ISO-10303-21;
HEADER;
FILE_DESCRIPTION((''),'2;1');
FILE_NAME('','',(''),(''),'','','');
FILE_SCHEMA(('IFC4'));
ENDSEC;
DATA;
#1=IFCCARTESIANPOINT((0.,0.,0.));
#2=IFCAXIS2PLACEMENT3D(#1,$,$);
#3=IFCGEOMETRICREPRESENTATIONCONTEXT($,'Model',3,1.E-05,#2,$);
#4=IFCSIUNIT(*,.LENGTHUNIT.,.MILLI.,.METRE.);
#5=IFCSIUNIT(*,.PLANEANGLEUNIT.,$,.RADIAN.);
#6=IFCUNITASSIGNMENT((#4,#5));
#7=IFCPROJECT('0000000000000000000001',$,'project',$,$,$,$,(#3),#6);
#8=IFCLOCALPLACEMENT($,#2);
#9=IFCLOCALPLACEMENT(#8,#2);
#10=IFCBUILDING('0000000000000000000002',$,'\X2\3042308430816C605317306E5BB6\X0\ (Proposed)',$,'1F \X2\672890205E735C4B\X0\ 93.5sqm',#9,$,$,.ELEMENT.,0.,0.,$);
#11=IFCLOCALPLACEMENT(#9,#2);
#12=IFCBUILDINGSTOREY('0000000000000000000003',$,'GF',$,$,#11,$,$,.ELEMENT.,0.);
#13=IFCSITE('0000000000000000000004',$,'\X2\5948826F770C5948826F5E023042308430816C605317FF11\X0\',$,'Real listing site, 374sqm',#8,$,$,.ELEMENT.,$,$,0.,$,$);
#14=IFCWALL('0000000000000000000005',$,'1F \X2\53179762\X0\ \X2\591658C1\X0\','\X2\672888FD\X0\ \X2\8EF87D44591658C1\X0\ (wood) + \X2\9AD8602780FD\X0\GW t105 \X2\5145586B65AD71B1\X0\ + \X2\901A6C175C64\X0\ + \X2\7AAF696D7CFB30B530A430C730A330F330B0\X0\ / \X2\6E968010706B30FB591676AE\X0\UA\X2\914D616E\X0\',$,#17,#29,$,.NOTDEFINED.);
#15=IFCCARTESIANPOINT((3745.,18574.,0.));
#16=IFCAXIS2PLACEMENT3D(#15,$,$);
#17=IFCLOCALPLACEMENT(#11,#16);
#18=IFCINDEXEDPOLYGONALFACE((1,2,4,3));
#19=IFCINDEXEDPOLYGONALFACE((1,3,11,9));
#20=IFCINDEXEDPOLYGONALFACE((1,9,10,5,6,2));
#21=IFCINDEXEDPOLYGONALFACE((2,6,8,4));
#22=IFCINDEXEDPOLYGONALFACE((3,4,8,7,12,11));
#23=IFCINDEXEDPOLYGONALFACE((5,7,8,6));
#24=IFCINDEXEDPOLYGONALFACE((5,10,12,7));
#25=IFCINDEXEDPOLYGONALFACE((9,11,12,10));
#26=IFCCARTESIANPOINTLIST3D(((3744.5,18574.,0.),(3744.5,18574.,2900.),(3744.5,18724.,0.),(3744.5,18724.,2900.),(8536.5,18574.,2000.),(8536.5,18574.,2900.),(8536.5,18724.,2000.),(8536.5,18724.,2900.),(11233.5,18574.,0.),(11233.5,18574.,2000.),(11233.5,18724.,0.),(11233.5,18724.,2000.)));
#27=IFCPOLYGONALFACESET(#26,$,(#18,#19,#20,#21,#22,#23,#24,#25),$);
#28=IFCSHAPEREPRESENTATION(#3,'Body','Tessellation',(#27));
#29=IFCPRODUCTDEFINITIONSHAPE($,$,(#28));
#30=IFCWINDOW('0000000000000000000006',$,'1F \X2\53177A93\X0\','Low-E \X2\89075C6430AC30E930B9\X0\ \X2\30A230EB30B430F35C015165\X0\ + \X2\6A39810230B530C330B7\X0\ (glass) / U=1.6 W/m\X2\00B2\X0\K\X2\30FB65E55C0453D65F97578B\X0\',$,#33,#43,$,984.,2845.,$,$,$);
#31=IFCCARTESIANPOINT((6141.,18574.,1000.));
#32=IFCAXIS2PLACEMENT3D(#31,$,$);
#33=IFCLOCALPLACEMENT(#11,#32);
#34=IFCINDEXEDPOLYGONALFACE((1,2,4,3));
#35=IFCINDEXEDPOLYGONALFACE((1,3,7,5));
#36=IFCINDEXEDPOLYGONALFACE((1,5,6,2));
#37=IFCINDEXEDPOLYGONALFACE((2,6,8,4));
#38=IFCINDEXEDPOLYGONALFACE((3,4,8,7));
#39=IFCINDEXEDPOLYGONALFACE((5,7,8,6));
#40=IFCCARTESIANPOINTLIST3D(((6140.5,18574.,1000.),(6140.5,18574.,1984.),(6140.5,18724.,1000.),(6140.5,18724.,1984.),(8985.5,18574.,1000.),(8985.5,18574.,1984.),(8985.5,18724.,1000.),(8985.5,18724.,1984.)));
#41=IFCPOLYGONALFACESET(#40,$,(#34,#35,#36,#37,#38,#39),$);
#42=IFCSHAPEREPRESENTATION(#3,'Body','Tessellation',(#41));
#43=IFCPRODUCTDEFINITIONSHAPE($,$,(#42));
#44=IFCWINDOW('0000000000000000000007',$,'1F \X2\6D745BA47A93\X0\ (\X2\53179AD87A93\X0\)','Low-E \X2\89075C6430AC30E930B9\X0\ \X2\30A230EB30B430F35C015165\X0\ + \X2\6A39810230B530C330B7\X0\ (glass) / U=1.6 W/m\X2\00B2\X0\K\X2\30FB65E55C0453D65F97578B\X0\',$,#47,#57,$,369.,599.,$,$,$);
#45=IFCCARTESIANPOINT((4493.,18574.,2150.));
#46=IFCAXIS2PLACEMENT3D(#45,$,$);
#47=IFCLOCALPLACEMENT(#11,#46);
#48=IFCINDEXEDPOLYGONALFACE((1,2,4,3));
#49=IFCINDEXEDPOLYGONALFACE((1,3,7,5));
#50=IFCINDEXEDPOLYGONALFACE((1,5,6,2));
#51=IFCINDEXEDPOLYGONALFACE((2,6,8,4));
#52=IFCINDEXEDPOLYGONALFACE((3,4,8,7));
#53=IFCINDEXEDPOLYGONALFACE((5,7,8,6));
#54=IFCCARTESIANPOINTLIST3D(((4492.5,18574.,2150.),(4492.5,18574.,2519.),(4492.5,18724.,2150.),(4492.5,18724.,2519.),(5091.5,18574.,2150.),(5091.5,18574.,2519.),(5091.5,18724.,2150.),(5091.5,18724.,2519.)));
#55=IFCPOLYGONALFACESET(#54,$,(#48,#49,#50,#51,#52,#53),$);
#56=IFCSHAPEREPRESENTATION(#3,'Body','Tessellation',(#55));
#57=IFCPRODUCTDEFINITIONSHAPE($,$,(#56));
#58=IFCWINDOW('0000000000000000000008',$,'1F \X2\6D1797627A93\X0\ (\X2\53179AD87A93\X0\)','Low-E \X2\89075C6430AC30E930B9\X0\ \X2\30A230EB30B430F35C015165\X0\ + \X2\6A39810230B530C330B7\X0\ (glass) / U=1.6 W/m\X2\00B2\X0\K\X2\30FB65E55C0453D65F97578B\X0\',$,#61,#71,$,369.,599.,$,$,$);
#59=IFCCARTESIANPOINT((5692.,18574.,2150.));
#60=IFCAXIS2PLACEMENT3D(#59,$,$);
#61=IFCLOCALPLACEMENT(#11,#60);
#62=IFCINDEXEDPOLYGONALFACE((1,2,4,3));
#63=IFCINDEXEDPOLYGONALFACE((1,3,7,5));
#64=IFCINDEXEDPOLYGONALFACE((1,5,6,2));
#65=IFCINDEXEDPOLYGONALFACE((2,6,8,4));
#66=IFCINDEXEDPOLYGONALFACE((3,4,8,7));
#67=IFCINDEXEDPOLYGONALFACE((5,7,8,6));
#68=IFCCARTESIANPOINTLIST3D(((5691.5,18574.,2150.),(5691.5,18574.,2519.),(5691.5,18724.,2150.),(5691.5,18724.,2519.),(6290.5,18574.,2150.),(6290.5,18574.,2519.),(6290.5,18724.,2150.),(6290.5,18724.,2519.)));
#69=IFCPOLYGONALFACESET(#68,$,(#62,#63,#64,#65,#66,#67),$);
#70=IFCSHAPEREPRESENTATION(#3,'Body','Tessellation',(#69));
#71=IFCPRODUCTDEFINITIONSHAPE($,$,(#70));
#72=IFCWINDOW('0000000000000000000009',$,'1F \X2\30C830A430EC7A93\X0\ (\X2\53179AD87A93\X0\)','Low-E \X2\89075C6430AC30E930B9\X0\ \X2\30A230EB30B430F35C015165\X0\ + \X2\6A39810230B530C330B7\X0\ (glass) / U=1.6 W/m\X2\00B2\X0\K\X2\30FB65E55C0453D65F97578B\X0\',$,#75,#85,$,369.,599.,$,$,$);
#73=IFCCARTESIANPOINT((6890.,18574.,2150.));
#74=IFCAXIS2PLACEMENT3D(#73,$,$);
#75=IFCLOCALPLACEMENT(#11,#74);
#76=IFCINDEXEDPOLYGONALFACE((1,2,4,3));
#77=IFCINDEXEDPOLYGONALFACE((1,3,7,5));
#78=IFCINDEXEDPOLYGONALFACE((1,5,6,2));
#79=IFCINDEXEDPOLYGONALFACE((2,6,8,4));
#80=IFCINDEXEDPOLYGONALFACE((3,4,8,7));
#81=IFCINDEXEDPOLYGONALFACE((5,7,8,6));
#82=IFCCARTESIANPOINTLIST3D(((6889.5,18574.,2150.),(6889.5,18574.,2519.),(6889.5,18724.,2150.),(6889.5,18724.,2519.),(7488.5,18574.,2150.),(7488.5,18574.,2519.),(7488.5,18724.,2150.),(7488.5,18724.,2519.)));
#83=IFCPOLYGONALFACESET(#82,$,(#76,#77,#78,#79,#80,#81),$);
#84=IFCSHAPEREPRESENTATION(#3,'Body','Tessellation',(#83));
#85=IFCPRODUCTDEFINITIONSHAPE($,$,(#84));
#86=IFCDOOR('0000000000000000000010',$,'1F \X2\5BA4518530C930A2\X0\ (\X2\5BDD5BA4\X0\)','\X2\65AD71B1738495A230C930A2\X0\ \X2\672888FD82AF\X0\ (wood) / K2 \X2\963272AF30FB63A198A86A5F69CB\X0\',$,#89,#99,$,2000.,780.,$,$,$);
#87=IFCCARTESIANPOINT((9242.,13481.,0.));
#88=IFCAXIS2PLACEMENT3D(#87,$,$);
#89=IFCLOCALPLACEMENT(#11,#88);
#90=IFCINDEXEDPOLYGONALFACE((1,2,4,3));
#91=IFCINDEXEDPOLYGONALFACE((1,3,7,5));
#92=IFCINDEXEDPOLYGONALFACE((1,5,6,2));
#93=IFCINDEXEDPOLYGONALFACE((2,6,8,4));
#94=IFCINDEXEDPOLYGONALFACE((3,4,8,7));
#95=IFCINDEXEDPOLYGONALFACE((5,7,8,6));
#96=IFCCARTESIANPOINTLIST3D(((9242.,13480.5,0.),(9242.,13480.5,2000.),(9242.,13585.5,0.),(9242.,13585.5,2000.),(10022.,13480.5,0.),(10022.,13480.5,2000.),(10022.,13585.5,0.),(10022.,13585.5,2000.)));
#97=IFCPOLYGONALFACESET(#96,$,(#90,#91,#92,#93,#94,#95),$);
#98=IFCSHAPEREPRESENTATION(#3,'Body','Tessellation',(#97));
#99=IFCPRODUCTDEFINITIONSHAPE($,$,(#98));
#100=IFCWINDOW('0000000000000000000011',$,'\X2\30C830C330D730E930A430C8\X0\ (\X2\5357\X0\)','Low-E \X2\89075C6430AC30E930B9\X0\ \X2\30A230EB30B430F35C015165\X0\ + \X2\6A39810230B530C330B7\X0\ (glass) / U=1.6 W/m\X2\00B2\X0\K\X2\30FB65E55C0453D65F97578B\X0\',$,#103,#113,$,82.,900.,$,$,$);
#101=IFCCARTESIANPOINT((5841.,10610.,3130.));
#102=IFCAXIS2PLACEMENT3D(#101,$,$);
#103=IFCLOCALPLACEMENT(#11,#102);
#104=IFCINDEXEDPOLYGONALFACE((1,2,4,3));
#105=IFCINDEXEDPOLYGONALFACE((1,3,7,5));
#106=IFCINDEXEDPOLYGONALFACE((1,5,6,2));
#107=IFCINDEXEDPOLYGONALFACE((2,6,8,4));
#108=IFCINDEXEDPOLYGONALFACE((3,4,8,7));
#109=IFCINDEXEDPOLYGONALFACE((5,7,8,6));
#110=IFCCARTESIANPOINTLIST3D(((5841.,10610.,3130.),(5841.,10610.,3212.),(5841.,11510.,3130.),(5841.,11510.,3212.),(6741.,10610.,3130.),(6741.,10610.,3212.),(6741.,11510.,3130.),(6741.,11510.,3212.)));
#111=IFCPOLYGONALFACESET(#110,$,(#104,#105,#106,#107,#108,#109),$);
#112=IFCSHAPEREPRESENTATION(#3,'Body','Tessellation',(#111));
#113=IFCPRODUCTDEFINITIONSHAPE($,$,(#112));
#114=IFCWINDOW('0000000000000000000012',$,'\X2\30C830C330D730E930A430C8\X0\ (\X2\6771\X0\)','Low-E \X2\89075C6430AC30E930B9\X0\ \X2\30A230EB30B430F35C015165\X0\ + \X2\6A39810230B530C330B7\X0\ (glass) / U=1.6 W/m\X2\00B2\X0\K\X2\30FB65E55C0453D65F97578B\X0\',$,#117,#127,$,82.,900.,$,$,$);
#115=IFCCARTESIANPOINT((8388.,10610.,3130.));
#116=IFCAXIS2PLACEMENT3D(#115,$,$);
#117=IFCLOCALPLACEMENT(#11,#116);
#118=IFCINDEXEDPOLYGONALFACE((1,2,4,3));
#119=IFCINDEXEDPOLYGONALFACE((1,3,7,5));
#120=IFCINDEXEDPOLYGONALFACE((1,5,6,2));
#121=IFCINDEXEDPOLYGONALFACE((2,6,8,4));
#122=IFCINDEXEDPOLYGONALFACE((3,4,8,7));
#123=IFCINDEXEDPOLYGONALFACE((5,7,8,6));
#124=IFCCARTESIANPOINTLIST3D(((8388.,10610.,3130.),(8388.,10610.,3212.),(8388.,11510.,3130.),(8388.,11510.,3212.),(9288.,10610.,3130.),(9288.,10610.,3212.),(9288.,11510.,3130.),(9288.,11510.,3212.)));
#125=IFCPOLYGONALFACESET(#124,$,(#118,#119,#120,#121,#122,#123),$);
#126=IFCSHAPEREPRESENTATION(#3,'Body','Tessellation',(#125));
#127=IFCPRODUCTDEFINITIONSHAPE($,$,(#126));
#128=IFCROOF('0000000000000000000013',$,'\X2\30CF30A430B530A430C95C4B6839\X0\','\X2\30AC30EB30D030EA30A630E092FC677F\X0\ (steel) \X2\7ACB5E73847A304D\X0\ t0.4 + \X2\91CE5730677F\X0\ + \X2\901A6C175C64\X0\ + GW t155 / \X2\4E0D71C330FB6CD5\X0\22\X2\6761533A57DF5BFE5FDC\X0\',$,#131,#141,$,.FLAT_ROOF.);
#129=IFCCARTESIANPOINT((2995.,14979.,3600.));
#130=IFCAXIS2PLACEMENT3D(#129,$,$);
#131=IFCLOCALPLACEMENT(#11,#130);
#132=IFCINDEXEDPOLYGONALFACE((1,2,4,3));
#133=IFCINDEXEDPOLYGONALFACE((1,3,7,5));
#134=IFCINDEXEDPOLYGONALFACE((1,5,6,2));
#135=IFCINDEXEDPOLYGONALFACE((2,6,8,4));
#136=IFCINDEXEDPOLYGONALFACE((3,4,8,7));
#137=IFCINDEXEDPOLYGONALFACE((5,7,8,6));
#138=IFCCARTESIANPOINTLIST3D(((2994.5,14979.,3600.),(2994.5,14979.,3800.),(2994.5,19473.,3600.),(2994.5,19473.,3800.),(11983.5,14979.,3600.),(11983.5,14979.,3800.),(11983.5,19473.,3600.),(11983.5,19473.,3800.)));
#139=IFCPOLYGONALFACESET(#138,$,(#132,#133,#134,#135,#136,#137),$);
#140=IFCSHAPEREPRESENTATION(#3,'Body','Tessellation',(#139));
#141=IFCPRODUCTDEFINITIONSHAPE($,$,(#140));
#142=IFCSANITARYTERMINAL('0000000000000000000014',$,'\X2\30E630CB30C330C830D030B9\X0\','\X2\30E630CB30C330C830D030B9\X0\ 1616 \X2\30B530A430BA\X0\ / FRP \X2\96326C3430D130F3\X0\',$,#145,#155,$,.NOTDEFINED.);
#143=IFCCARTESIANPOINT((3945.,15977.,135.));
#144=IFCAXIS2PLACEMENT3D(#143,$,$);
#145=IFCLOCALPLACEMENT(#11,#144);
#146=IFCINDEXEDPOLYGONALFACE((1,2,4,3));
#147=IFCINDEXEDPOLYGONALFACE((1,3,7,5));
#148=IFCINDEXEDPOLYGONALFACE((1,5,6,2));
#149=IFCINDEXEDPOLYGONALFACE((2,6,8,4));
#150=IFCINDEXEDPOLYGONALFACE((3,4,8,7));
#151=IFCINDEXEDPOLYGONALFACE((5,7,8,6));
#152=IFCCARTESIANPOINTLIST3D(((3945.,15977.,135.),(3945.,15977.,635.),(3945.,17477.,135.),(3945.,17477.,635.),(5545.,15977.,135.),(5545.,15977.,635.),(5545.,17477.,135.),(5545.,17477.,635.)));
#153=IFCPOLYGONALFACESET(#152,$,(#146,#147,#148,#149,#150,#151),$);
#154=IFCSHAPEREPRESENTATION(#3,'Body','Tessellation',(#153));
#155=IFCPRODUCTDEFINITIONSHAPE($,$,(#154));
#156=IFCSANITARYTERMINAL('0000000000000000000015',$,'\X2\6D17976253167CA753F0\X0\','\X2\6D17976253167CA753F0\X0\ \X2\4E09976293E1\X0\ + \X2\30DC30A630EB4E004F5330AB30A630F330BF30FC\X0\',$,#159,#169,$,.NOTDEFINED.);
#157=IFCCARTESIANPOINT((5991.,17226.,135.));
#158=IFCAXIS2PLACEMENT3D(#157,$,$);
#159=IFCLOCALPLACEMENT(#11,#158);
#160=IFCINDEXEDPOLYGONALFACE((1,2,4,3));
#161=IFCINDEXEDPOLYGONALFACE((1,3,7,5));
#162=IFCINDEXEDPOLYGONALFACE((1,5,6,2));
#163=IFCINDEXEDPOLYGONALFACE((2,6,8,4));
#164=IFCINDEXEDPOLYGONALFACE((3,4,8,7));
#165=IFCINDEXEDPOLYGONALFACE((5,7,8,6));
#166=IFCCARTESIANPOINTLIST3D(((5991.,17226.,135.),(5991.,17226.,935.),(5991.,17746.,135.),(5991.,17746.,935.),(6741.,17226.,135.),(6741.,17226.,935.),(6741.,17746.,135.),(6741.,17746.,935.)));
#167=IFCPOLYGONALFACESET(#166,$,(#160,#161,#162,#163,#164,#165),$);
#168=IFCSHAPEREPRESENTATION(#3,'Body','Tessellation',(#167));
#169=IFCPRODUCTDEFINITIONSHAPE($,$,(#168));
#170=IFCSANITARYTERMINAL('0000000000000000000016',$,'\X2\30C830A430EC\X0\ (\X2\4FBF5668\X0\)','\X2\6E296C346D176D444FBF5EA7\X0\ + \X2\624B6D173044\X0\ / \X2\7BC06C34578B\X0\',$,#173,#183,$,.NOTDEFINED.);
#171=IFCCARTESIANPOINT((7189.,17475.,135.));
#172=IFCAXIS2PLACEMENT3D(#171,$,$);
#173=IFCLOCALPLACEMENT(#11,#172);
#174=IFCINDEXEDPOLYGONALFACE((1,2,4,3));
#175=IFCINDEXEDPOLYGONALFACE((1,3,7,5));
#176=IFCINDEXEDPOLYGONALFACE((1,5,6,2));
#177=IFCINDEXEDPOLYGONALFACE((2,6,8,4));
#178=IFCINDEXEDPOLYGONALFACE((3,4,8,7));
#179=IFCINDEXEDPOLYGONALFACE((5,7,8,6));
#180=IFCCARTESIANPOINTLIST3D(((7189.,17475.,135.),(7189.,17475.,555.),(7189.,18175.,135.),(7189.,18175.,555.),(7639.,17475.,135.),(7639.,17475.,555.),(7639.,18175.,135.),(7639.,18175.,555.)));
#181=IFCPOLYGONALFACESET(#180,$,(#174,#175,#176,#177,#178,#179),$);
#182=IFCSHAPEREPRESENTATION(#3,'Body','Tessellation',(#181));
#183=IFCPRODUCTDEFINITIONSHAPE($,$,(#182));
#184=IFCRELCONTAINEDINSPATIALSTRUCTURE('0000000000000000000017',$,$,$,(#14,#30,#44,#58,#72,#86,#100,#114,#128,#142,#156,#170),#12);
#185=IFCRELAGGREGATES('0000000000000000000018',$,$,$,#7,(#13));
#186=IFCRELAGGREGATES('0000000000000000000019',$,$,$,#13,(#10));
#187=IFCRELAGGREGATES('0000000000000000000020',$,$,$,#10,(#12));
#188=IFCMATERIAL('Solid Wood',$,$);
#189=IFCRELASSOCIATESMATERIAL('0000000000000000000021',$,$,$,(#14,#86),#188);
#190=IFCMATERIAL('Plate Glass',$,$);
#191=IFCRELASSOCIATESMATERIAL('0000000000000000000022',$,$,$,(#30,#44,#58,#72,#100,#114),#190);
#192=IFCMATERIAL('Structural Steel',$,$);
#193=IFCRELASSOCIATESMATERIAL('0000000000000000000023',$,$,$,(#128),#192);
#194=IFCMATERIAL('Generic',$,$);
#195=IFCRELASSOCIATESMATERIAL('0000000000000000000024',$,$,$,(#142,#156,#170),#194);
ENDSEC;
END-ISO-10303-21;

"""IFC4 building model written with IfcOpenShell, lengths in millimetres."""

from ifc_helpers import new_model, si_unit, frame, frame_2d, origin, place, context, project, spatial, rectangle, extrude, material, element, fill, save


model = new_model("IFC4")

# Units and contexts
model_context = context("Model", 3, precision=1e-05, world=origin())
ifc_project = project(units=[si_unit("LENGTHUNIT", "METRE", prefix="MILLI"), si_unit("PLANEANGLEUNIT", "RADIAN")], contexts=[model_context])

# Site, building, storey
site_placement = place(None, origin())
site = spatial("IfcSite", under=ifc_project, at=site_placement, Name="奈良県奈良市あやめ池北１", ObjectType="Real listing site, 374sqm", CompositionType="ELEMENT", RefElevation=0.0)
building_placement = place(site_placement, origin())
building = spatial("IfcBuilding", under=site, at=building_placement, Name="あやめ池北の家 (Proposed)", ObjectType="1F 木造平屋 93.5sqm", CompositionType="ELEMENT", ElevationOfRefHeight=0.0, ElevationOfTerrain=0.0)
storey_placement = place(building_placement, origin())
storey = spatial("IfcBuildingStorey", under=building, at=storey_placement, Name="GF", CompositionType="ELEMENT", Elevation=0.0)

# Shared definitions
ifc_material_1 = material(Name="Solid Wood")

# Wall, openings, windows
wall_1_placement = place(storey_placement, frame((3745.0, 18574.0, 0.0)))
wall_1 = element("IfcWall", 1, at=wall_1_placement, inside=storey, material=ifc_material_1, Name="1F 北面 外壁", Description="木製 軸組外壁 (wood) + 高性能GW t105 充填断熱 + 通気層 + 窯業系サイディング / 準耐火・外皮UA配慮", PredefinedType="NOTDEFINED", context=model_context, shape_type="SweptSolid", body=[
    extrude(rectangle(XDim=7489.0, YDim=150.0, at=frame_2d((3744.0, 75.0))), frame((3745.0, 18574.0, 0.0)), (0.0, 0.0, 1.0), 2900.0),
])
opening_1_placement = place(storey_placement, frame((6141.0, 18574.0, 1000.0)))
opening_1 = element("IfcOpeningElement", 2, at=opening_1_placement, cuts=wall_1, PredefinedType="NOTDEFINED", context=model_context, shape_type="SweptSolid", body=[
    extrude(rectangle(XDim=2845.0, YDim=150.0, at=frame_2d((1422.0, 75.0))), frame((6141.0, 18574.0, 1000.0)), (0.0, 0.0, 1.0), 984.0),
])
opening_2_placement = place(storey_placement, frame((4493.0, 18574.0, 2150.0)))
opening_2 = element("IfcOpeningElement", 3, at=opening_2_placement, cuts=wall_1, PredefinedType="NOTDEFINED", context=model_context, shape_type="SweptSolid", body=[
    extrude(rectangle(XDim=599.0, YDim=150.0, at=frame_2d((299.0, 75.0))), frame((4493.0, 18574.0, 2150.0)), (0.0, 0.0, 1.0), 369.0),
])
opening_3_placement = place(storey_placement, frame((5692.0, 18574.0, 2150.0)))
opening_3 = element("IfcOpeningElement", 4, at=opening_3_placement, cuts=wall_1, PredefinedType="NOTDEFINED", context=model_context, shape_type="SweptSolid", body=[
    extrude(rectangle(XDim=599.0, YDim=150.0, at=frame_2d((299.0, 75.0))), frame((5692.0, 18574.0, 2150.0)), (0.0, 0.0, 1.0), 369.0),
])
opening_4_placement = place(storey_placement, frame((6890.0, 18574.0, 2150.0)))
opening_4 = element("IfcOpeningElement", 5, at=opening_4_placement, cuts=wall_1, PredefinedType="NOTDEFINED", context=model_context, shape_type="SweptSolid", body=[
    extrude(rectangle(XDim=599.0, YDim=150.0, at=frame_2d((299.0, 75.0))), frame((6890.0, 18574.0, 2150.0)), (0.0, 0.0, 1.0), 369.0),
])
ifc_material_2 = material(Name="Plate Glass")
window_1_placement = place(storey_placement, frame((6141.0, 18574.0, 1000.0)))
window_1 = element("IfcWindow", 6, at=window_1_placement, inside=storey, material=ifc_material_2, Name="1F 北窓", Description="Low-E 複層ガラス アルゴン封入 + 樹脂サッシ (glass) / U=1.6 W/m²K・日射取得型", OverallHeight=984.0, OverallWidth=2845.0, context=model_context, shape_type="SweptSolid", body=[
    extrude(rectangle(XDim=2845.0, YDim=150.0, at=frame_2d((1422.0, 75.0))), frame((6141.0, 18574.0, 1000.0)), (0.0, 0.0, 1.0), 984.0),
])
fill(opening_1, window_1)
window_2_placement = place(storey_placement, frame((4493.0, 18574.0, 2150.0)))
window_2 = element("IfcWindow", 7, at=window_2_placement, inside=storey, material=ifc_material_2, Name="1F 浴室窓 (北高窓)", Description="Low-E 複層ガラス アルゴン封入 + 樹脂サッシ (glass) / U=1.6 W/m²K・日射取得型", OverallHeight=369.0, OverallWidth=599.0, context=model_context, shape_type="SweptSolid", body=[
    extrude(rectangle(XDim=599.0, YDim=150.0, at=frame_2d((299.0, 75.0))), frame((4493.0, 18574.0, 2150.0)), (0.0, 0.0, 1.0), 369.0),
])
fill(opening_2, window_2)
window_3_placement = place(storey_placement, frame((5692.0, 18574.0, 2150.0)))
window_3 = element("IfcWindow", 8, at=window_3_placement, inside=storey, material=ifc_material_2, Name="1F 洗面窓 (北高窓)", Description="Low-E 複層ガラス アルゴン封入 + 樹脂サッシ (glass) / U=1.6 W/m²K・日射取得型", OverallHeight=369.0, OverallWidth=599.0, context=model_context, shape_type="SweptSolid", body=[
    extrude(rectangle(XDim=599.0, YDim=150.0, at=frame_2d((299.0, 75.0))), frame((5692.0, 18574.0, 2150.0)), (0.0, 0.0, 1.0), 369.0),
])
fill(opening_3, window_3)
window_4_placement = place(storey_placement, frame((6890.0, 18574.0, 2150.0)))
window_4 = element("IfcWindow", 9, at=window_4_placement, inside=storey, material=ifc_material_2, Name="1F トイレ窓 (北高窓)", Description="Low-E 複層ガラス アルゴン封入 + 樹脂サッシ (glass) / U=1.6 W/m²K・日射取得型", OverallHeight=369.0, OverallWidth=599.0, context=model_context, shape_type="SweptSolid", body=[
    extrude(rectangle(XDim=599.0, YDim=150.0, at=frame_2d((299.0, 75.0))), frame((6890.0, 18574.0, 2150.0)), (0.0, 0.0, 1.0), 369.0),
])
fill(opening_4, window_4)

# Door
door_1_placement = place(storey_placement, frame((9242.0, 13481.0, 0.0)))
element("IfcDoor", 10, at=door_1_placement, inside=storey, material=ifc_material_1, Name="1F 室内ドア (寝室)", Description="断熱玄関ドア 木製芯 (wood) / K2 防犯・採風機構", OverallHeight=2000.0, OverallWidth=780.0, context=model_context, shape_type="SweptSolid", body=[
    extrude(rectangle(XDim=780.0, YDim=105.0, at=frame_2d((390.0, 52.0))), frame((9242.0, 13481.0, 0.0)), (0.0, 0.0, 1.0), 2000.0),
])

# Windows
window_5_placement = place(storey_placement, frame((5841.0, 10610.0, 3130.0)))
element("IfcWindow", 11, at=window_5_placement, inside=storey, material=ifc_material_2, Name="トップライト (南)", Description="Low-E 複層ガラス アルゴン封入 + 樹脂サッシ (glass) / U=1.6 W/m²K・日射取得型", OverallHeight=82.0, OverallWidth=900.0, context=model_context, shape_type="SweptSolid", body=[
    extrude(rectangle(XDim=900.0, YDim=900.0, at=frame_2d((450.0, 450.0))), frame((5841.0, 10610.0, 3130.0)), (0.0, 0.0, 1.0), 82.0),
])
window_6_placement = place(storey_placement, frame((8388.0, 10610.0, 3130.0)))
element("IfcWindow", 12, at=window_6_placement, inside=storey, material=ifc_material_2, Name="トップライト (東)", Description="Low-E 複層ガラス アルゴン封入 + 樹脂サッシ (glass) / U=1.6 W/m²K・日射取得型", OverallHeight=82.0, OverallWidth=900.0, context=model_context, shape_type="SweptSolid", body=[
    extrude(rectangle(XDim=900.0, YDim=900.0, at=frame_2d((450.0, 450.0))), frame((8388.0, 10610.0, 3130.0)), (0.0, 0.0, 1.0), 82.0),
])

# Roof
ifc_material_3 = material(Name="Structural Steel")
roof_placement = place(storey_placement, frame((2995.0, 14979.0, 3600.0)))
element("IfcRoof", 13, at=roof_placement, inside=storey, material=ifc_material_3, Name="ハイサイド屋根", Description="ガルバリウム鋼板 (steel) 立平葺き t0.4 + 野地板 + 通気層 + GW t155 / 不燃・法22条区域対応", PredefinedType="FLAT_ROOF", context=model_context, shape_type="SweptSolid", body=[
    extrude(rectangle(XDim=8989.0, YDim=4494.0, at=frame_2d((4494.0, 2247.0))), frame((2995.0, 14979.0, 3600.0)), (0.0, 0.0, 1.0), 200.0),
])

# Sanitary terminals
ifc_material_4 = material(Name="Generic")
sanitary_terminal_1_placement = place(storey_placement, frame((3945.0, 15977.0, 135.0)))
element("IfcSanitaryTerminal", 14, at=sanitary_terminal_1_placement, inside=storey, material=ifc_material_4, Name="ユニットバス", Description="ユニットバス 1616 サイズ / FRP 防水パン", PredefinedType="NOTDEFINED", context=model_context, shape_type="SweptSolid", body=[
    extrude(rectangle(XDim=1600.0, YDim=1500.0, at=frame_2d((800.0, 750.0))), frame((3945.0, 15977.0, 135.0)), (0.0, 0.0, 1.0), 500.0),
])
sanitary_terminal_2_placement = place(storey_placement, frame((5991.0, 17226.0, 135.0)))
element("IfcSanitaryTerminal", 15, at=sanitary_terminal_2_placement, inside=storey, material=ifc_material_4, Name="洗面化粧台", Description="洗面化粧台 三面鏡 + ボウル一体カウンター", PredefinedType="NOTDEFINED", context=model_context, shape_type="SweptSolid", body=[
    extrude(rectangle(XDim=750.0, YDim=520.0, at=frame_2d((375.0, 260.0))), frame((5991.0, 17226.0, 135.0)), (0.0, 0.0, 1.0), 800.0),
])
sanitary_terminal_3_placement = place(storey_placement, frame((7189.0, 17475.0, 135.0)))
element("IfcSanitaryTerminal", 16, at=sanitary_terminal_3_placement, inside=storey, material=ifc_material_4, Name="トイレ (便器)", Description="温水洗浄便座 + 手洗い / 節水型", PredefinedType="NOTDEFINED", context=model_context, shape_type="SweptSolid", body=[
    extrude(rectangle(XDim=450.0, YDim=700.0, at=frame_2d((225.0, 350.0))), frame((7189.0, 17475.0, 135.0)), (0.0, 0.0, 1.0), 420.0),
])

save(model, "model.ifc")
